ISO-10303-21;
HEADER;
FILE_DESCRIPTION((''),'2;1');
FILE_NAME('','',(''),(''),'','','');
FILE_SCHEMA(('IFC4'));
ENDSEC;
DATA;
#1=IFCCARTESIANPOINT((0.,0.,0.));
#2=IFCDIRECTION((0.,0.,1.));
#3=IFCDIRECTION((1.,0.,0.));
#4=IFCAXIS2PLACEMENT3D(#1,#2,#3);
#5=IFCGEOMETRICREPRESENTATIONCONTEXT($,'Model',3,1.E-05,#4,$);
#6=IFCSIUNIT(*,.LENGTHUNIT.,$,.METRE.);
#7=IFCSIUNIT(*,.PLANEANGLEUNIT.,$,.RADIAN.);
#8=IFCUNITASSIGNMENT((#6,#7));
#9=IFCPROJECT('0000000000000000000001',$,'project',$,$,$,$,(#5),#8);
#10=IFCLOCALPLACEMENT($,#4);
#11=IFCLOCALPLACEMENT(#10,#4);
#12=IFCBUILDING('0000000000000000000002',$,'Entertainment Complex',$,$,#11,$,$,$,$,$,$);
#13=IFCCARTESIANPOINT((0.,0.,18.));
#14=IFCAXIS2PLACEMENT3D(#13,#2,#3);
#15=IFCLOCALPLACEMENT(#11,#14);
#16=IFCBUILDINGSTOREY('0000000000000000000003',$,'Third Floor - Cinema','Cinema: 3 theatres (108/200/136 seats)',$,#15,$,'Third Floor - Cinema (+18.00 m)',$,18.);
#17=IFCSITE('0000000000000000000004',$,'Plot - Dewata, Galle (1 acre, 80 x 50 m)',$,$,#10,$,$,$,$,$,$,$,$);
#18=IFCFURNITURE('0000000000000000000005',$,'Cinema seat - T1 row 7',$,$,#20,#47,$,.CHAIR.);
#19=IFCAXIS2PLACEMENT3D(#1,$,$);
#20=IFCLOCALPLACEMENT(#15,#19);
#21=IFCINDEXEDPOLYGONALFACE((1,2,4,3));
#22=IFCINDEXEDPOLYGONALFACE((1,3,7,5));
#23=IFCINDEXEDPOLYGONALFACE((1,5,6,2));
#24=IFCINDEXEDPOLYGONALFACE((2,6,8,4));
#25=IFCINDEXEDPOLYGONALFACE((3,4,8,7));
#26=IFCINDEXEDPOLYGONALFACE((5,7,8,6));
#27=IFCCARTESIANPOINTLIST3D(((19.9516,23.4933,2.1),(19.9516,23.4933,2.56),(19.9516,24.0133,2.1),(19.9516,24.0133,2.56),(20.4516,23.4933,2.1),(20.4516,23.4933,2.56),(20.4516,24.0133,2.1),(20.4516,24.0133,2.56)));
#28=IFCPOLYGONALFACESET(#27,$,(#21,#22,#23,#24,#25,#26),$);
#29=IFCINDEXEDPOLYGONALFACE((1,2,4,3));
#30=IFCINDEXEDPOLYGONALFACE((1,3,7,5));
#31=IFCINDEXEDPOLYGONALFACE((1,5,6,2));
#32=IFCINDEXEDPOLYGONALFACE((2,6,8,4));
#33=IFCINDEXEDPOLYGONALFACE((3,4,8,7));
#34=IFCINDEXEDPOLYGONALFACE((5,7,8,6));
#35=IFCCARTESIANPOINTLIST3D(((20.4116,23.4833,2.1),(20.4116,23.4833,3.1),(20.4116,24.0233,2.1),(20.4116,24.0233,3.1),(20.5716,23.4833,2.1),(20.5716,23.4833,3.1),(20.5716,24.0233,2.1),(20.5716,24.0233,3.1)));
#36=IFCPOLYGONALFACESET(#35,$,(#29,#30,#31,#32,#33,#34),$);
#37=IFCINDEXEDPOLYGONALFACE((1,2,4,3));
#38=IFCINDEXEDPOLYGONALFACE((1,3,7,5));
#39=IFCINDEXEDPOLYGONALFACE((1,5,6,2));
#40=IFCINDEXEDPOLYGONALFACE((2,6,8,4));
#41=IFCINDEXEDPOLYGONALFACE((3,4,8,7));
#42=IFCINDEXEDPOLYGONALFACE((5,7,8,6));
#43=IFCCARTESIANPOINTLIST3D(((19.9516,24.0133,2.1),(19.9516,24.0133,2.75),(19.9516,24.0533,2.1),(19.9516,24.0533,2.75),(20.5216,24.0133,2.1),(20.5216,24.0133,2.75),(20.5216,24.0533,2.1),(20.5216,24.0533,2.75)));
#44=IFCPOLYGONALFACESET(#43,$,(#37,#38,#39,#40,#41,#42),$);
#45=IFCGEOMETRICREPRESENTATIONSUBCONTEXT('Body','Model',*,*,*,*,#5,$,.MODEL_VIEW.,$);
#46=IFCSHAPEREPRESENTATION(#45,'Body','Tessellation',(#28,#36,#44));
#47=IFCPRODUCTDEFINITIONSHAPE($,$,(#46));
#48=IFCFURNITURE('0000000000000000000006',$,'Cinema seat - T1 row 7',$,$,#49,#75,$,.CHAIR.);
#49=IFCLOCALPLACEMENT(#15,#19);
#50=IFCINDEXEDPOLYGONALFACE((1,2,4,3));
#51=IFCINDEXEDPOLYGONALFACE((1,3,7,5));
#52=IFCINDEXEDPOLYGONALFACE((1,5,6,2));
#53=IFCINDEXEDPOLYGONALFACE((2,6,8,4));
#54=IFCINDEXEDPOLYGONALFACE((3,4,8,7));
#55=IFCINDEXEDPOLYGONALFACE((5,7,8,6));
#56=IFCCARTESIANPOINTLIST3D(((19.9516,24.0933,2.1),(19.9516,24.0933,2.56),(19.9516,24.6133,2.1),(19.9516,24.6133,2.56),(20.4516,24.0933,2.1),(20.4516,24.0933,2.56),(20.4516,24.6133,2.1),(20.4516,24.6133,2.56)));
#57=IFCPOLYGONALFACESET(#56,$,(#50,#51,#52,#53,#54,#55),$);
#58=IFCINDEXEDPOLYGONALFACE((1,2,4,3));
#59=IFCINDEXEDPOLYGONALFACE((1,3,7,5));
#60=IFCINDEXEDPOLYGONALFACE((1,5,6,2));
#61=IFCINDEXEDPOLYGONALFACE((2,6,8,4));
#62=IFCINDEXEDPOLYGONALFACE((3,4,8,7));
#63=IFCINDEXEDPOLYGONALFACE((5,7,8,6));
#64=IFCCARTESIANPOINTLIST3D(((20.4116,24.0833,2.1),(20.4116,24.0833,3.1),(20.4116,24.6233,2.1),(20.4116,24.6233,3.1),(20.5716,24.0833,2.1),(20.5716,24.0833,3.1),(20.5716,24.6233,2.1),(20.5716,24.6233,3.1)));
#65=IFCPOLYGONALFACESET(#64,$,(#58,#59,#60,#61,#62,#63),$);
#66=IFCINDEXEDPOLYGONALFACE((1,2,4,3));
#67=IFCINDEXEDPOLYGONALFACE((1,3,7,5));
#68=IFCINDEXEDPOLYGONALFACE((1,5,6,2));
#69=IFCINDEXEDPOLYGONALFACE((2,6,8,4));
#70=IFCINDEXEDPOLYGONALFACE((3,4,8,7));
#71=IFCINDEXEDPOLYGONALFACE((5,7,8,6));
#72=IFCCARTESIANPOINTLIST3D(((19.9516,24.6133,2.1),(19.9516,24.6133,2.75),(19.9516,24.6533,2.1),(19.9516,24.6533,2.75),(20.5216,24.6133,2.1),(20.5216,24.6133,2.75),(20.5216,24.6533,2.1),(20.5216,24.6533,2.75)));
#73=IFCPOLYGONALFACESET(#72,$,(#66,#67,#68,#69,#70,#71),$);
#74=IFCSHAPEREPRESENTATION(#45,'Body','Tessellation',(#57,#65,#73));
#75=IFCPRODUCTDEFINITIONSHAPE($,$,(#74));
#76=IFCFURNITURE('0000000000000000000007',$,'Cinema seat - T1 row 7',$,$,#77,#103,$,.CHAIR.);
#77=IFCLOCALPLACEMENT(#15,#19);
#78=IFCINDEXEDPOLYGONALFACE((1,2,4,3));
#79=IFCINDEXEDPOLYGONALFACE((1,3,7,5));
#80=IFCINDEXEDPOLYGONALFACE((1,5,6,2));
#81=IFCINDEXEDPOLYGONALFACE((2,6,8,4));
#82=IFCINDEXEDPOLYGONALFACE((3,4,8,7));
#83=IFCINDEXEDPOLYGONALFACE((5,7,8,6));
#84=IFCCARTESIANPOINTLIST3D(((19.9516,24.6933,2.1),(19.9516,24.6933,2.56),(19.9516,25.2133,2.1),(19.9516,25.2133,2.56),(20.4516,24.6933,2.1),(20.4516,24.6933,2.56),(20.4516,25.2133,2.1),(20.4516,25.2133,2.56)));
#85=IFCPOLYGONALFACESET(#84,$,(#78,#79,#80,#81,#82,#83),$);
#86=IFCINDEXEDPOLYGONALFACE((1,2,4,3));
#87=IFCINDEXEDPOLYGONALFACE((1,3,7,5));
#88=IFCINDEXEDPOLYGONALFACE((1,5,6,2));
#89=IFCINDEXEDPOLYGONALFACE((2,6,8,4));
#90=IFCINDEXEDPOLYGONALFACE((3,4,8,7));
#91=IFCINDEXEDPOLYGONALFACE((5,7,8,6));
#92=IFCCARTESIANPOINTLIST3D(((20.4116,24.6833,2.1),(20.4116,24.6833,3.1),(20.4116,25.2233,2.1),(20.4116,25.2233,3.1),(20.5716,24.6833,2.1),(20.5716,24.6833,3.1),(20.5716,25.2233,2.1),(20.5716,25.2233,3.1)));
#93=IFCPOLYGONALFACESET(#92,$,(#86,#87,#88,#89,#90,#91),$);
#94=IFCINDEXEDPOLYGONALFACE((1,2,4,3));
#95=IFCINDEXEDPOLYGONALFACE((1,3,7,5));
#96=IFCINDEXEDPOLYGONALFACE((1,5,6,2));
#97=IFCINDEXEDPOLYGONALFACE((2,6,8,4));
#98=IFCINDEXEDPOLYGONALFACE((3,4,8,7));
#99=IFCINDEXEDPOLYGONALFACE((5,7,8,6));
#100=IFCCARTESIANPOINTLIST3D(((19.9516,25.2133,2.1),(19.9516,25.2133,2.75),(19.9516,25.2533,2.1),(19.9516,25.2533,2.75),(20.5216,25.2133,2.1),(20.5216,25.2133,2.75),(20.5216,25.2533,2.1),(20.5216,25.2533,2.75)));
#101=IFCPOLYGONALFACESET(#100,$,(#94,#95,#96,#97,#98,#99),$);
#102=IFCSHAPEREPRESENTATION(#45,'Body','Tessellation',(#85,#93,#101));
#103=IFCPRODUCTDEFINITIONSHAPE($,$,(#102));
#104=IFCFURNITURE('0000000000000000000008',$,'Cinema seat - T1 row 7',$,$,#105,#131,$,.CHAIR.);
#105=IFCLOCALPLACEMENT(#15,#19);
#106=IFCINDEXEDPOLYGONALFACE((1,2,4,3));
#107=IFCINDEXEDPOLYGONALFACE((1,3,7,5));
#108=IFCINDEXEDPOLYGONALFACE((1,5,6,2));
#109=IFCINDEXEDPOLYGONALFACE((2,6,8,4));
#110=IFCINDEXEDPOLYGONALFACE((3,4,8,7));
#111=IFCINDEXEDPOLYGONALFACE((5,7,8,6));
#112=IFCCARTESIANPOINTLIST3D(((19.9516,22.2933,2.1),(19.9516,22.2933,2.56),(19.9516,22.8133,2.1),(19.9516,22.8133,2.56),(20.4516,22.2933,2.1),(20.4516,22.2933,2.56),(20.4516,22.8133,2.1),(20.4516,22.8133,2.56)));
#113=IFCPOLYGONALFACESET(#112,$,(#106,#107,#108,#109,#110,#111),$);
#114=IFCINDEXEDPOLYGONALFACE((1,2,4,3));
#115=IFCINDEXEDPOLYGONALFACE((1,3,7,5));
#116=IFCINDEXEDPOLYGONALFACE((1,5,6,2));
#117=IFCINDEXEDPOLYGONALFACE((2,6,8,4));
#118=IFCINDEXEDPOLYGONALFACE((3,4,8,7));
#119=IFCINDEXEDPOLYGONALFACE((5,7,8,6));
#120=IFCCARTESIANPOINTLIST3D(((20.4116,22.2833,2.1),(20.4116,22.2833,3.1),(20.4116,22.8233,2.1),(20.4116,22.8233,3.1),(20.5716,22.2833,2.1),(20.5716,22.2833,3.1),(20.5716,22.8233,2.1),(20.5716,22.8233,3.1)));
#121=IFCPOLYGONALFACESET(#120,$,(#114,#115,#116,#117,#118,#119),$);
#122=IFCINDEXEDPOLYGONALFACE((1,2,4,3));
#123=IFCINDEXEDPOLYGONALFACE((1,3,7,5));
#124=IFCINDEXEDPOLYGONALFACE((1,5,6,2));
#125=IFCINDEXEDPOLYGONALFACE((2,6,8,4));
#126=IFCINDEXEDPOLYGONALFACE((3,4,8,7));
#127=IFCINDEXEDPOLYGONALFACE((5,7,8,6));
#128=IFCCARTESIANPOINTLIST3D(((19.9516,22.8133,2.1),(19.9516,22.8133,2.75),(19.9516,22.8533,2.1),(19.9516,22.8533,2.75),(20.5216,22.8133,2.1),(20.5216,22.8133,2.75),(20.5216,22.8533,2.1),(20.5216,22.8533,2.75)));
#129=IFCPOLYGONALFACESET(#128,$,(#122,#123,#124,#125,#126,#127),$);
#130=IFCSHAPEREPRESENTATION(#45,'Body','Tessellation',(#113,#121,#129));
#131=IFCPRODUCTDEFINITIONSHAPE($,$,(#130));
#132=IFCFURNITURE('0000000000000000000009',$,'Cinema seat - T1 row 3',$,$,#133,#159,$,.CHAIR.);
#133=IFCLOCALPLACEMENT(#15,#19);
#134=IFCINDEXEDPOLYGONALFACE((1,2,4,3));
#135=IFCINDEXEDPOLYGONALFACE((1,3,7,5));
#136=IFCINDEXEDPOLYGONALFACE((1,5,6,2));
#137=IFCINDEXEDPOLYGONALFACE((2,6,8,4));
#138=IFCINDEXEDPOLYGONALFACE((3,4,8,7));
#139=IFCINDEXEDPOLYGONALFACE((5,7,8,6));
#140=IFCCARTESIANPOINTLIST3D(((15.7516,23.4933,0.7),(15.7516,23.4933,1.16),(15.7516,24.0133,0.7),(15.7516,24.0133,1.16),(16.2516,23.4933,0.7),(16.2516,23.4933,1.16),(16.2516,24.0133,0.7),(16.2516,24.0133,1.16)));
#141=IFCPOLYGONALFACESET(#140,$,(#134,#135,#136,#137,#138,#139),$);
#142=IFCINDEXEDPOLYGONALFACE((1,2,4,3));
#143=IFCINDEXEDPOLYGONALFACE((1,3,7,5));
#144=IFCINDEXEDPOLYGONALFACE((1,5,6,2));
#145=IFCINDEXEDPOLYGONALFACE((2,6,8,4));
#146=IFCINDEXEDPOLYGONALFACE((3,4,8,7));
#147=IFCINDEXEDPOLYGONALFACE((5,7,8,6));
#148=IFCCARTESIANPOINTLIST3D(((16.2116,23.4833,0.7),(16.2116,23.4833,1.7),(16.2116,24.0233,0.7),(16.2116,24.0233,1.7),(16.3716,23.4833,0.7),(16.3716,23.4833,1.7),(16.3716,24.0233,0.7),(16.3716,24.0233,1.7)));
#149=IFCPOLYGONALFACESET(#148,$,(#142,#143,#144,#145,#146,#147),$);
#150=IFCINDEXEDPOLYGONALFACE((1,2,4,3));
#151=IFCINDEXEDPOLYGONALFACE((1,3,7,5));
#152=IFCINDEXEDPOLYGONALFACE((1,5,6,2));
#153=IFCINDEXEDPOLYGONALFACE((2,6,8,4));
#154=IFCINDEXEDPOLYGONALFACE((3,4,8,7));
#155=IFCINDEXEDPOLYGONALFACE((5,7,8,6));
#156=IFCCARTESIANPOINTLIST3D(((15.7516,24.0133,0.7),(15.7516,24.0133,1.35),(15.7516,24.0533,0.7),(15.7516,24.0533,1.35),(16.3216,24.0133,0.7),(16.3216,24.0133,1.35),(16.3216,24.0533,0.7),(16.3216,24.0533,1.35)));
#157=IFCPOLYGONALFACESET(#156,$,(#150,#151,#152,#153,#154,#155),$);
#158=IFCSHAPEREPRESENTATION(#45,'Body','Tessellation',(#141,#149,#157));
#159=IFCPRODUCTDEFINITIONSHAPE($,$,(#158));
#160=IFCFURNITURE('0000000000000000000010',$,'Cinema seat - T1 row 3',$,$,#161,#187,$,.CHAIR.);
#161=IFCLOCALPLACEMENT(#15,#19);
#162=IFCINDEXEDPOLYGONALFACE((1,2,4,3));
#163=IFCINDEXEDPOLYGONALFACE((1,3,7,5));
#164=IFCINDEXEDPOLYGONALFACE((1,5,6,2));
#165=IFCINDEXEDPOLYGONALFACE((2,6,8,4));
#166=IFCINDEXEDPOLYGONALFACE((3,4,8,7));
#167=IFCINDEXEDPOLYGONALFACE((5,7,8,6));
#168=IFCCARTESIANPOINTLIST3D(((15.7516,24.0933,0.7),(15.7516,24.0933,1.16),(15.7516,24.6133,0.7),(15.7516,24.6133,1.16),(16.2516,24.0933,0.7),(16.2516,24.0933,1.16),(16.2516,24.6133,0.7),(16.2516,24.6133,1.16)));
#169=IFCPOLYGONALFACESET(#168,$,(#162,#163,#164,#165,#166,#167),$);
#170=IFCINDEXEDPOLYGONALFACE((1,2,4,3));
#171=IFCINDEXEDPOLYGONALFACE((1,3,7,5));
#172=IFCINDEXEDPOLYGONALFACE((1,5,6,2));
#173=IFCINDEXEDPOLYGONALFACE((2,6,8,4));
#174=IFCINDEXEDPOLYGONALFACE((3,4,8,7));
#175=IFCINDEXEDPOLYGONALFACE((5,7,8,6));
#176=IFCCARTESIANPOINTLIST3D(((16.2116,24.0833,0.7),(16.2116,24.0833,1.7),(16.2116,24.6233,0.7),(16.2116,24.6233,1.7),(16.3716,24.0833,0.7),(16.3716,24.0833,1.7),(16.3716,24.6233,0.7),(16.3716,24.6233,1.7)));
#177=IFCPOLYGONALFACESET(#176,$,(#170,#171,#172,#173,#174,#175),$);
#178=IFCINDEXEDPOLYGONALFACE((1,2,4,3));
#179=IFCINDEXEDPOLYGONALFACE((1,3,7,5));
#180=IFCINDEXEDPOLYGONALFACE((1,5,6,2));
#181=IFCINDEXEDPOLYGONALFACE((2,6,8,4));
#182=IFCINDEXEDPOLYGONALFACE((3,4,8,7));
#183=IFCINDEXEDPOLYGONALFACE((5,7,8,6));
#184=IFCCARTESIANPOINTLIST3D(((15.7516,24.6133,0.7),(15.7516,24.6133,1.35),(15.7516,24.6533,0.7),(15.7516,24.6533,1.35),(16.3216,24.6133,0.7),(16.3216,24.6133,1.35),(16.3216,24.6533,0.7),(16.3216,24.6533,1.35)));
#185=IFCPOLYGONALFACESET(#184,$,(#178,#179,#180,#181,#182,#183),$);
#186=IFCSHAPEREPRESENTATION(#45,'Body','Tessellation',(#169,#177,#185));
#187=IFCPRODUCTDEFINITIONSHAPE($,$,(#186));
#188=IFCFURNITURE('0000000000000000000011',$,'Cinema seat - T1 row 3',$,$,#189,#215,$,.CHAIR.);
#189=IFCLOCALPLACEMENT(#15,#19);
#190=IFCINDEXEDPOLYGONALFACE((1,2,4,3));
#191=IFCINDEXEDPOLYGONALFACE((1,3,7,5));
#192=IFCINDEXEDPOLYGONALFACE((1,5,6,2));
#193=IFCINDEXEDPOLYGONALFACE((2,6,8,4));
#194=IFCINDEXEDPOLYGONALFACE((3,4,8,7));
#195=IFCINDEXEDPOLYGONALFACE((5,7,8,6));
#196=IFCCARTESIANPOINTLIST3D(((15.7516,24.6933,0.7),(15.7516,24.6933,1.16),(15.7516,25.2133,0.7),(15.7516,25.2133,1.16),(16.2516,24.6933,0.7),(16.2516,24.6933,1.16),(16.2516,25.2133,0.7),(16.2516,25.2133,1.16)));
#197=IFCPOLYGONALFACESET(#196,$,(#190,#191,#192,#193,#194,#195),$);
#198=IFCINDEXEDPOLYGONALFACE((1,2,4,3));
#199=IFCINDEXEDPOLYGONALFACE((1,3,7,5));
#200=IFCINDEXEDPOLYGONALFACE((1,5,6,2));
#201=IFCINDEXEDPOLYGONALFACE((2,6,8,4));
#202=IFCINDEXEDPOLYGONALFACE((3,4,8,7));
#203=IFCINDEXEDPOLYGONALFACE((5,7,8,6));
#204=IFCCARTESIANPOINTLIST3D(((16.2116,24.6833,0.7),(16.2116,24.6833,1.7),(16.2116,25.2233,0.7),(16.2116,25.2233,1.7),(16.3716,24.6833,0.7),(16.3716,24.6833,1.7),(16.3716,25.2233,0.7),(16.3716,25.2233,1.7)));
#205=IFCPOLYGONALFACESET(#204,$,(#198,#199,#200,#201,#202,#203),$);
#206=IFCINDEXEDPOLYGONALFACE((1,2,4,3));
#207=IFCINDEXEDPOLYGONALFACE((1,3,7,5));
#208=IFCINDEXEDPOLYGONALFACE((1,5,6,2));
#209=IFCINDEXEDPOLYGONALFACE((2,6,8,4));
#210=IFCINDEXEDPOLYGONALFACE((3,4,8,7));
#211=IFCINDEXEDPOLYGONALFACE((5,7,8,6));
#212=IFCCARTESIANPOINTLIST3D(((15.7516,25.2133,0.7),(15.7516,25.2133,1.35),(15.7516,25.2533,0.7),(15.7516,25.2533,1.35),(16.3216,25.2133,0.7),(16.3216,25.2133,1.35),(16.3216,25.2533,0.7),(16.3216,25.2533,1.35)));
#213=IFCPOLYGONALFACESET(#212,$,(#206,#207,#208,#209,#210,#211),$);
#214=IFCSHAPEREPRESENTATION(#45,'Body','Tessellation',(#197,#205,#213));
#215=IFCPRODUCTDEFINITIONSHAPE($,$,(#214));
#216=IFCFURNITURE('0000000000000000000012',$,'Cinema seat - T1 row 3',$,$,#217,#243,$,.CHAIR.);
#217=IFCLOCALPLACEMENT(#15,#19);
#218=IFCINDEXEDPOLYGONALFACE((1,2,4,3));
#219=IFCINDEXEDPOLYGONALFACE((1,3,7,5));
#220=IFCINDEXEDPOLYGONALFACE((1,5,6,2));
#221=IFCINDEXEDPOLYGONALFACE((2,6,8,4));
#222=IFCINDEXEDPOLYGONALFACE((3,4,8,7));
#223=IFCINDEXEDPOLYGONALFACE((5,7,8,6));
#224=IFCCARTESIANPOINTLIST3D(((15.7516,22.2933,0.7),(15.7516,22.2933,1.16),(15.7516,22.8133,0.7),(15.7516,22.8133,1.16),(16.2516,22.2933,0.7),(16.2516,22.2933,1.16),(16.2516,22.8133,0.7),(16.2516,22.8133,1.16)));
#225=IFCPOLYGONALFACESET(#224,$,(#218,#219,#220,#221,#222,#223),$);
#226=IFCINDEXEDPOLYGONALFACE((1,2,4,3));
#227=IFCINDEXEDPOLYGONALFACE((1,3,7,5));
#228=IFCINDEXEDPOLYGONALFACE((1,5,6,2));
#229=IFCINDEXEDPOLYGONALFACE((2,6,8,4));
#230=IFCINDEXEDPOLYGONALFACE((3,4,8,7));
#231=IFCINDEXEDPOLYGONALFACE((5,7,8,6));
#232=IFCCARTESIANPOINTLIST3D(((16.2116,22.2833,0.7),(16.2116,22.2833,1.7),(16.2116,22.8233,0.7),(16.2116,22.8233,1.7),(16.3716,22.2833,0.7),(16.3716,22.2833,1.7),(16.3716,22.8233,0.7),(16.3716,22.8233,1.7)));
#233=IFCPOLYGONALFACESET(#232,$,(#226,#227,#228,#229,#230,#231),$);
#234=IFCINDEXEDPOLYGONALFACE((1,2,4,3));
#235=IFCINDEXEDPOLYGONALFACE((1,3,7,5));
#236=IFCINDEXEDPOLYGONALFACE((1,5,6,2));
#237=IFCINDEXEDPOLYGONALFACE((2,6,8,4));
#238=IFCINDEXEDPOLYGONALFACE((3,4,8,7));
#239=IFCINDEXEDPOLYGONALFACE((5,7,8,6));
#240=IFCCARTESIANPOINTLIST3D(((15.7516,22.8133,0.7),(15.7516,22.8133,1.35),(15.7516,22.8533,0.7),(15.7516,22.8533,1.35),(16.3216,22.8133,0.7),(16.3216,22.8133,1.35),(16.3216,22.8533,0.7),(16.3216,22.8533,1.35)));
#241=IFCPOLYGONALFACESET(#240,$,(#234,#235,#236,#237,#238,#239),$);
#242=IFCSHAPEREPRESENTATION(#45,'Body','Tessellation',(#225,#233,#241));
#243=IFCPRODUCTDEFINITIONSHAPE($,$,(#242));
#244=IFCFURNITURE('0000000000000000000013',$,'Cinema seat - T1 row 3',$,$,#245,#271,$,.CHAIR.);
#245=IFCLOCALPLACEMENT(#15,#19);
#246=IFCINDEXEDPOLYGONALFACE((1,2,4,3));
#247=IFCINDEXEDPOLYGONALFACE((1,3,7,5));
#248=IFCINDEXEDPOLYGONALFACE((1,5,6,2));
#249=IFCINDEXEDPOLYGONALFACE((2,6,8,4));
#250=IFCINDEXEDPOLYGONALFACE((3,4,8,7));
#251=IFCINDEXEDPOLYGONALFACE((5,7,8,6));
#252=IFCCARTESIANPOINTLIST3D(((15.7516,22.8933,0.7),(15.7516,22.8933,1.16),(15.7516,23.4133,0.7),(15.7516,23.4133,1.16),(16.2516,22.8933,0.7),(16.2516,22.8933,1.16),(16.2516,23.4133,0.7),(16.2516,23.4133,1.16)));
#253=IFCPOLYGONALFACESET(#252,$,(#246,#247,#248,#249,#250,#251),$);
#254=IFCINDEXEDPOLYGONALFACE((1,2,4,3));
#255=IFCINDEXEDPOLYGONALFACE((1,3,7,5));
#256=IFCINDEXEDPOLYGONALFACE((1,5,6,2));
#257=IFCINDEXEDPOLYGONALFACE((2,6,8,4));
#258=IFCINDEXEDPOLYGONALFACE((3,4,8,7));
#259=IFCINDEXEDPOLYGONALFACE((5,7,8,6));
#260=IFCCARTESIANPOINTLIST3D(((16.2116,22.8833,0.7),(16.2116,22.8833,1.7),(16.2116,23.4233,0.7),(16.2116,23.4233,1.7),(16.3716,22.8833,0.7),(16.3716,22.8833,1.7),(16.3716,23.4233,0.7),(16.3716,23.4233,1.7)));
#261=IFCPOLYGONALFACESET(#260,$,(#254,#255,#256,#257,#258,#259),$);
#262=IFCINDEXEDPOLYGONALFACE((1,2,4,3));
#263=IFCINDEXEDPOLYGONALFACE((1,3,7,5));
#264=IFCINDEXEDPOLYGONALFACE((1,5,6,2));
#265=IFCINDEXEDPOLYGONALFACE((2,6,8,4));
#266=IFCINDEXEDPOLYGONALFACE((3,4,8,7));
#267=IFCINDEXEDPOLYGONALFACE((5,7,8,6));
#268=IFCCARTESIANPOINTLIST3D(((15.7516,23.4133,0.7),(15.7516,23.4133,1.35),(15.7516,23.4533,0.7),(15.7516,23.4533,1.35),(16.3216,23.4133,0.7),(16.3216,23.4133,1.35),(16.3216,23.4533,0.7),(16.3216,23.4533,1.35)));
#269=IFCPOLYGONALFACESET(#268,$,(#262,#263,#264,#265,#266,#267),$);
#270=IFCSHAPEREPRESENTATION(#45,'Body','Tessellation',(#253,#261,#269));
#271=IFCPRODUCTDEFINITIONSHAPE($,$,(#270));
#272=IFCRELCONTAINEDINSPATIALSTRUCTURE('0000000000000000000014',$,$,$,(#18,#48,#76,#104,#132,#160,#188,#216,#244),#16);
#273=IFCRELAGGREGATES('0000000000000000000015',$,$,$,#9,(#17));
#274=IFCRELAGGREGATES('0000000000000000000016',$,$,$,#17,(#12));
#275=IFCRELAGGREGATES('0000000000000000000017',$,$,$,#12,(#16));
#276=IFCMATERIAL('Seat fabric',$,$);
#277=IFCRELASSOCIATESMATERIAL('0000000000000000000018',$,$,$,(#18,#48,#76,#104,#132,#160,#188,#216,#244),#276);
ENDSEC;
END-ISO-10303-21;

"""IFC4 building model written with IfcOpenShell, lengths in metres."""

from ifc_helpers import new_model, si_unit, frame, origin_with_axes, place, context, subcontext, project, spatial, polyline, outline, extrude, material, element, save


model = new_model("IFC4")

# Units and contexts
model_context = context("Model", 3, precision=1e-05, world=origin_with_axes())
body_context = subcontext(model_context, "Body", "Model", "MODEL_VIEW")
ifc_project = project(units=[si_unit("LENGTHUNIT", "METRE"), si_unit("PLANEANGLEUNIT", "RADIAN")], contexts=[model_context])

# Site, building, storey
site_placement = place(None, origin_with_axes())
site = spatial("IfcSite", under=ifc_project, at=site_placement, Name="Plot - Dewata, Galle (1 acre, 80 x 50 m)")
building_placement = place(site_placement, origin_with_axes())
building = spatial("IfcBuilding", under=site, at=building_placement, Name="Entertainment Complex")
storey_placement = place(building_placement, frame((0.0, 0.0, 18.0), z_axis=(0.0, 0.0, 1.0), x_axis=(1.0, 0.0, 0.0)))
storey = spatial("IfcBuildingStorey", under=building, at=storey_placement, Name="Third Floor - Cinema", Description="Cinema: 3 theatres (108/200/136 seats)", LongName="Third Floor - Cinema (+18.00 m)", Elevation=18.0)

# Furniture
ifc_material = material(Name="Seat fabric")
for number, where, z_axis, x_axis, name in (
    (1, (20.5716, 23.7533, 2.1), (0.0, 0.0, 1.0), (1.0, 0.0, 0.0), "Cinema seat - T1 row 7"),
    (2, (20.5716, 24.3533, 2.1), (0.0, 0.0, 1.0), (1.0, 0.0, 0.0), "Cinema seat - T1 row 7"),
    (3, (20.5716, 24.9533, 2.1), (0.0, 0.0, 1.0), (1.0, 0.0, 0.0), "Cinema seat - T1 row 7"),
    (4, (20.5716, 22.5533, 2.1), (0.0, 0.0, 1.0), (1.0, 0.0, 0.0), "Cinema seat - T1 row 7"),
    (5, (16.3716, 23.7533, 0.7), (0.0, 0.0, 1.0), (1.0, 0.0, 0.0), "Cinema seat - T1 row 3"),
    (6, (16.3716, 24.3533, 0.7), (0.0, 0.0, 1.0), (1.0, 0.0, 0.0), "Cinema seat - T1 row 3"),
    (7, (16.3716, 24.9533, 0.7), (0.0, 0.0, 1.0), (1.0, 0.0, 0.0), "Cinema seat - T1 row 3"),
    (8, (16.3716, 22.5533, 0.7), (0.0, 0.0, 1.0), (1.0, 0.0, 0.0), "Cinema seat - T1 row 3"),
    (9, (16.3716, 23.1533, 0.7), (0.0, 0.0, 1.0), (1.0, 0.0, 0.0), "Cinema seat - T1 row 3"),
):
    element("IfcFurniture", number, at=place(storey_placement, frame(where, z_axis=z_axis, x_axis=x_axis)), inside=storey, material=ifc_material, Name=name, PredefinedType="CHAIR", context=body_context, shape_type="SweptSolid", body=[
        extrude(outline(polyline([(-0.62, -0.26), (-0.12, -0.26), (-0.12, 0.26), (-0.62, 0.26), (-0.62, -0.26)])), origin_with_axes(), (0.0, 0.0, 1.0), 0.46),
        extrude(outline(polyline([(-0.16, -0.27), (0.0, -0.27), (0.0, 0.27), (-0.16, 0.27), (-0.16, -0.27)])), origin_with_axes(), (0.0, 0.0, 1.0), 1.0),
        extrude(outline(polyline([(-0.62, 0.26), (-0.05, 0.26), (-0.05, 0.3), (-0.62, 0.3), (-0.62, 0.26)])), origin_with_axes(), (0.0, 0.0, 1.0), 0.65),
    ])

save(model, "model.ifc")
